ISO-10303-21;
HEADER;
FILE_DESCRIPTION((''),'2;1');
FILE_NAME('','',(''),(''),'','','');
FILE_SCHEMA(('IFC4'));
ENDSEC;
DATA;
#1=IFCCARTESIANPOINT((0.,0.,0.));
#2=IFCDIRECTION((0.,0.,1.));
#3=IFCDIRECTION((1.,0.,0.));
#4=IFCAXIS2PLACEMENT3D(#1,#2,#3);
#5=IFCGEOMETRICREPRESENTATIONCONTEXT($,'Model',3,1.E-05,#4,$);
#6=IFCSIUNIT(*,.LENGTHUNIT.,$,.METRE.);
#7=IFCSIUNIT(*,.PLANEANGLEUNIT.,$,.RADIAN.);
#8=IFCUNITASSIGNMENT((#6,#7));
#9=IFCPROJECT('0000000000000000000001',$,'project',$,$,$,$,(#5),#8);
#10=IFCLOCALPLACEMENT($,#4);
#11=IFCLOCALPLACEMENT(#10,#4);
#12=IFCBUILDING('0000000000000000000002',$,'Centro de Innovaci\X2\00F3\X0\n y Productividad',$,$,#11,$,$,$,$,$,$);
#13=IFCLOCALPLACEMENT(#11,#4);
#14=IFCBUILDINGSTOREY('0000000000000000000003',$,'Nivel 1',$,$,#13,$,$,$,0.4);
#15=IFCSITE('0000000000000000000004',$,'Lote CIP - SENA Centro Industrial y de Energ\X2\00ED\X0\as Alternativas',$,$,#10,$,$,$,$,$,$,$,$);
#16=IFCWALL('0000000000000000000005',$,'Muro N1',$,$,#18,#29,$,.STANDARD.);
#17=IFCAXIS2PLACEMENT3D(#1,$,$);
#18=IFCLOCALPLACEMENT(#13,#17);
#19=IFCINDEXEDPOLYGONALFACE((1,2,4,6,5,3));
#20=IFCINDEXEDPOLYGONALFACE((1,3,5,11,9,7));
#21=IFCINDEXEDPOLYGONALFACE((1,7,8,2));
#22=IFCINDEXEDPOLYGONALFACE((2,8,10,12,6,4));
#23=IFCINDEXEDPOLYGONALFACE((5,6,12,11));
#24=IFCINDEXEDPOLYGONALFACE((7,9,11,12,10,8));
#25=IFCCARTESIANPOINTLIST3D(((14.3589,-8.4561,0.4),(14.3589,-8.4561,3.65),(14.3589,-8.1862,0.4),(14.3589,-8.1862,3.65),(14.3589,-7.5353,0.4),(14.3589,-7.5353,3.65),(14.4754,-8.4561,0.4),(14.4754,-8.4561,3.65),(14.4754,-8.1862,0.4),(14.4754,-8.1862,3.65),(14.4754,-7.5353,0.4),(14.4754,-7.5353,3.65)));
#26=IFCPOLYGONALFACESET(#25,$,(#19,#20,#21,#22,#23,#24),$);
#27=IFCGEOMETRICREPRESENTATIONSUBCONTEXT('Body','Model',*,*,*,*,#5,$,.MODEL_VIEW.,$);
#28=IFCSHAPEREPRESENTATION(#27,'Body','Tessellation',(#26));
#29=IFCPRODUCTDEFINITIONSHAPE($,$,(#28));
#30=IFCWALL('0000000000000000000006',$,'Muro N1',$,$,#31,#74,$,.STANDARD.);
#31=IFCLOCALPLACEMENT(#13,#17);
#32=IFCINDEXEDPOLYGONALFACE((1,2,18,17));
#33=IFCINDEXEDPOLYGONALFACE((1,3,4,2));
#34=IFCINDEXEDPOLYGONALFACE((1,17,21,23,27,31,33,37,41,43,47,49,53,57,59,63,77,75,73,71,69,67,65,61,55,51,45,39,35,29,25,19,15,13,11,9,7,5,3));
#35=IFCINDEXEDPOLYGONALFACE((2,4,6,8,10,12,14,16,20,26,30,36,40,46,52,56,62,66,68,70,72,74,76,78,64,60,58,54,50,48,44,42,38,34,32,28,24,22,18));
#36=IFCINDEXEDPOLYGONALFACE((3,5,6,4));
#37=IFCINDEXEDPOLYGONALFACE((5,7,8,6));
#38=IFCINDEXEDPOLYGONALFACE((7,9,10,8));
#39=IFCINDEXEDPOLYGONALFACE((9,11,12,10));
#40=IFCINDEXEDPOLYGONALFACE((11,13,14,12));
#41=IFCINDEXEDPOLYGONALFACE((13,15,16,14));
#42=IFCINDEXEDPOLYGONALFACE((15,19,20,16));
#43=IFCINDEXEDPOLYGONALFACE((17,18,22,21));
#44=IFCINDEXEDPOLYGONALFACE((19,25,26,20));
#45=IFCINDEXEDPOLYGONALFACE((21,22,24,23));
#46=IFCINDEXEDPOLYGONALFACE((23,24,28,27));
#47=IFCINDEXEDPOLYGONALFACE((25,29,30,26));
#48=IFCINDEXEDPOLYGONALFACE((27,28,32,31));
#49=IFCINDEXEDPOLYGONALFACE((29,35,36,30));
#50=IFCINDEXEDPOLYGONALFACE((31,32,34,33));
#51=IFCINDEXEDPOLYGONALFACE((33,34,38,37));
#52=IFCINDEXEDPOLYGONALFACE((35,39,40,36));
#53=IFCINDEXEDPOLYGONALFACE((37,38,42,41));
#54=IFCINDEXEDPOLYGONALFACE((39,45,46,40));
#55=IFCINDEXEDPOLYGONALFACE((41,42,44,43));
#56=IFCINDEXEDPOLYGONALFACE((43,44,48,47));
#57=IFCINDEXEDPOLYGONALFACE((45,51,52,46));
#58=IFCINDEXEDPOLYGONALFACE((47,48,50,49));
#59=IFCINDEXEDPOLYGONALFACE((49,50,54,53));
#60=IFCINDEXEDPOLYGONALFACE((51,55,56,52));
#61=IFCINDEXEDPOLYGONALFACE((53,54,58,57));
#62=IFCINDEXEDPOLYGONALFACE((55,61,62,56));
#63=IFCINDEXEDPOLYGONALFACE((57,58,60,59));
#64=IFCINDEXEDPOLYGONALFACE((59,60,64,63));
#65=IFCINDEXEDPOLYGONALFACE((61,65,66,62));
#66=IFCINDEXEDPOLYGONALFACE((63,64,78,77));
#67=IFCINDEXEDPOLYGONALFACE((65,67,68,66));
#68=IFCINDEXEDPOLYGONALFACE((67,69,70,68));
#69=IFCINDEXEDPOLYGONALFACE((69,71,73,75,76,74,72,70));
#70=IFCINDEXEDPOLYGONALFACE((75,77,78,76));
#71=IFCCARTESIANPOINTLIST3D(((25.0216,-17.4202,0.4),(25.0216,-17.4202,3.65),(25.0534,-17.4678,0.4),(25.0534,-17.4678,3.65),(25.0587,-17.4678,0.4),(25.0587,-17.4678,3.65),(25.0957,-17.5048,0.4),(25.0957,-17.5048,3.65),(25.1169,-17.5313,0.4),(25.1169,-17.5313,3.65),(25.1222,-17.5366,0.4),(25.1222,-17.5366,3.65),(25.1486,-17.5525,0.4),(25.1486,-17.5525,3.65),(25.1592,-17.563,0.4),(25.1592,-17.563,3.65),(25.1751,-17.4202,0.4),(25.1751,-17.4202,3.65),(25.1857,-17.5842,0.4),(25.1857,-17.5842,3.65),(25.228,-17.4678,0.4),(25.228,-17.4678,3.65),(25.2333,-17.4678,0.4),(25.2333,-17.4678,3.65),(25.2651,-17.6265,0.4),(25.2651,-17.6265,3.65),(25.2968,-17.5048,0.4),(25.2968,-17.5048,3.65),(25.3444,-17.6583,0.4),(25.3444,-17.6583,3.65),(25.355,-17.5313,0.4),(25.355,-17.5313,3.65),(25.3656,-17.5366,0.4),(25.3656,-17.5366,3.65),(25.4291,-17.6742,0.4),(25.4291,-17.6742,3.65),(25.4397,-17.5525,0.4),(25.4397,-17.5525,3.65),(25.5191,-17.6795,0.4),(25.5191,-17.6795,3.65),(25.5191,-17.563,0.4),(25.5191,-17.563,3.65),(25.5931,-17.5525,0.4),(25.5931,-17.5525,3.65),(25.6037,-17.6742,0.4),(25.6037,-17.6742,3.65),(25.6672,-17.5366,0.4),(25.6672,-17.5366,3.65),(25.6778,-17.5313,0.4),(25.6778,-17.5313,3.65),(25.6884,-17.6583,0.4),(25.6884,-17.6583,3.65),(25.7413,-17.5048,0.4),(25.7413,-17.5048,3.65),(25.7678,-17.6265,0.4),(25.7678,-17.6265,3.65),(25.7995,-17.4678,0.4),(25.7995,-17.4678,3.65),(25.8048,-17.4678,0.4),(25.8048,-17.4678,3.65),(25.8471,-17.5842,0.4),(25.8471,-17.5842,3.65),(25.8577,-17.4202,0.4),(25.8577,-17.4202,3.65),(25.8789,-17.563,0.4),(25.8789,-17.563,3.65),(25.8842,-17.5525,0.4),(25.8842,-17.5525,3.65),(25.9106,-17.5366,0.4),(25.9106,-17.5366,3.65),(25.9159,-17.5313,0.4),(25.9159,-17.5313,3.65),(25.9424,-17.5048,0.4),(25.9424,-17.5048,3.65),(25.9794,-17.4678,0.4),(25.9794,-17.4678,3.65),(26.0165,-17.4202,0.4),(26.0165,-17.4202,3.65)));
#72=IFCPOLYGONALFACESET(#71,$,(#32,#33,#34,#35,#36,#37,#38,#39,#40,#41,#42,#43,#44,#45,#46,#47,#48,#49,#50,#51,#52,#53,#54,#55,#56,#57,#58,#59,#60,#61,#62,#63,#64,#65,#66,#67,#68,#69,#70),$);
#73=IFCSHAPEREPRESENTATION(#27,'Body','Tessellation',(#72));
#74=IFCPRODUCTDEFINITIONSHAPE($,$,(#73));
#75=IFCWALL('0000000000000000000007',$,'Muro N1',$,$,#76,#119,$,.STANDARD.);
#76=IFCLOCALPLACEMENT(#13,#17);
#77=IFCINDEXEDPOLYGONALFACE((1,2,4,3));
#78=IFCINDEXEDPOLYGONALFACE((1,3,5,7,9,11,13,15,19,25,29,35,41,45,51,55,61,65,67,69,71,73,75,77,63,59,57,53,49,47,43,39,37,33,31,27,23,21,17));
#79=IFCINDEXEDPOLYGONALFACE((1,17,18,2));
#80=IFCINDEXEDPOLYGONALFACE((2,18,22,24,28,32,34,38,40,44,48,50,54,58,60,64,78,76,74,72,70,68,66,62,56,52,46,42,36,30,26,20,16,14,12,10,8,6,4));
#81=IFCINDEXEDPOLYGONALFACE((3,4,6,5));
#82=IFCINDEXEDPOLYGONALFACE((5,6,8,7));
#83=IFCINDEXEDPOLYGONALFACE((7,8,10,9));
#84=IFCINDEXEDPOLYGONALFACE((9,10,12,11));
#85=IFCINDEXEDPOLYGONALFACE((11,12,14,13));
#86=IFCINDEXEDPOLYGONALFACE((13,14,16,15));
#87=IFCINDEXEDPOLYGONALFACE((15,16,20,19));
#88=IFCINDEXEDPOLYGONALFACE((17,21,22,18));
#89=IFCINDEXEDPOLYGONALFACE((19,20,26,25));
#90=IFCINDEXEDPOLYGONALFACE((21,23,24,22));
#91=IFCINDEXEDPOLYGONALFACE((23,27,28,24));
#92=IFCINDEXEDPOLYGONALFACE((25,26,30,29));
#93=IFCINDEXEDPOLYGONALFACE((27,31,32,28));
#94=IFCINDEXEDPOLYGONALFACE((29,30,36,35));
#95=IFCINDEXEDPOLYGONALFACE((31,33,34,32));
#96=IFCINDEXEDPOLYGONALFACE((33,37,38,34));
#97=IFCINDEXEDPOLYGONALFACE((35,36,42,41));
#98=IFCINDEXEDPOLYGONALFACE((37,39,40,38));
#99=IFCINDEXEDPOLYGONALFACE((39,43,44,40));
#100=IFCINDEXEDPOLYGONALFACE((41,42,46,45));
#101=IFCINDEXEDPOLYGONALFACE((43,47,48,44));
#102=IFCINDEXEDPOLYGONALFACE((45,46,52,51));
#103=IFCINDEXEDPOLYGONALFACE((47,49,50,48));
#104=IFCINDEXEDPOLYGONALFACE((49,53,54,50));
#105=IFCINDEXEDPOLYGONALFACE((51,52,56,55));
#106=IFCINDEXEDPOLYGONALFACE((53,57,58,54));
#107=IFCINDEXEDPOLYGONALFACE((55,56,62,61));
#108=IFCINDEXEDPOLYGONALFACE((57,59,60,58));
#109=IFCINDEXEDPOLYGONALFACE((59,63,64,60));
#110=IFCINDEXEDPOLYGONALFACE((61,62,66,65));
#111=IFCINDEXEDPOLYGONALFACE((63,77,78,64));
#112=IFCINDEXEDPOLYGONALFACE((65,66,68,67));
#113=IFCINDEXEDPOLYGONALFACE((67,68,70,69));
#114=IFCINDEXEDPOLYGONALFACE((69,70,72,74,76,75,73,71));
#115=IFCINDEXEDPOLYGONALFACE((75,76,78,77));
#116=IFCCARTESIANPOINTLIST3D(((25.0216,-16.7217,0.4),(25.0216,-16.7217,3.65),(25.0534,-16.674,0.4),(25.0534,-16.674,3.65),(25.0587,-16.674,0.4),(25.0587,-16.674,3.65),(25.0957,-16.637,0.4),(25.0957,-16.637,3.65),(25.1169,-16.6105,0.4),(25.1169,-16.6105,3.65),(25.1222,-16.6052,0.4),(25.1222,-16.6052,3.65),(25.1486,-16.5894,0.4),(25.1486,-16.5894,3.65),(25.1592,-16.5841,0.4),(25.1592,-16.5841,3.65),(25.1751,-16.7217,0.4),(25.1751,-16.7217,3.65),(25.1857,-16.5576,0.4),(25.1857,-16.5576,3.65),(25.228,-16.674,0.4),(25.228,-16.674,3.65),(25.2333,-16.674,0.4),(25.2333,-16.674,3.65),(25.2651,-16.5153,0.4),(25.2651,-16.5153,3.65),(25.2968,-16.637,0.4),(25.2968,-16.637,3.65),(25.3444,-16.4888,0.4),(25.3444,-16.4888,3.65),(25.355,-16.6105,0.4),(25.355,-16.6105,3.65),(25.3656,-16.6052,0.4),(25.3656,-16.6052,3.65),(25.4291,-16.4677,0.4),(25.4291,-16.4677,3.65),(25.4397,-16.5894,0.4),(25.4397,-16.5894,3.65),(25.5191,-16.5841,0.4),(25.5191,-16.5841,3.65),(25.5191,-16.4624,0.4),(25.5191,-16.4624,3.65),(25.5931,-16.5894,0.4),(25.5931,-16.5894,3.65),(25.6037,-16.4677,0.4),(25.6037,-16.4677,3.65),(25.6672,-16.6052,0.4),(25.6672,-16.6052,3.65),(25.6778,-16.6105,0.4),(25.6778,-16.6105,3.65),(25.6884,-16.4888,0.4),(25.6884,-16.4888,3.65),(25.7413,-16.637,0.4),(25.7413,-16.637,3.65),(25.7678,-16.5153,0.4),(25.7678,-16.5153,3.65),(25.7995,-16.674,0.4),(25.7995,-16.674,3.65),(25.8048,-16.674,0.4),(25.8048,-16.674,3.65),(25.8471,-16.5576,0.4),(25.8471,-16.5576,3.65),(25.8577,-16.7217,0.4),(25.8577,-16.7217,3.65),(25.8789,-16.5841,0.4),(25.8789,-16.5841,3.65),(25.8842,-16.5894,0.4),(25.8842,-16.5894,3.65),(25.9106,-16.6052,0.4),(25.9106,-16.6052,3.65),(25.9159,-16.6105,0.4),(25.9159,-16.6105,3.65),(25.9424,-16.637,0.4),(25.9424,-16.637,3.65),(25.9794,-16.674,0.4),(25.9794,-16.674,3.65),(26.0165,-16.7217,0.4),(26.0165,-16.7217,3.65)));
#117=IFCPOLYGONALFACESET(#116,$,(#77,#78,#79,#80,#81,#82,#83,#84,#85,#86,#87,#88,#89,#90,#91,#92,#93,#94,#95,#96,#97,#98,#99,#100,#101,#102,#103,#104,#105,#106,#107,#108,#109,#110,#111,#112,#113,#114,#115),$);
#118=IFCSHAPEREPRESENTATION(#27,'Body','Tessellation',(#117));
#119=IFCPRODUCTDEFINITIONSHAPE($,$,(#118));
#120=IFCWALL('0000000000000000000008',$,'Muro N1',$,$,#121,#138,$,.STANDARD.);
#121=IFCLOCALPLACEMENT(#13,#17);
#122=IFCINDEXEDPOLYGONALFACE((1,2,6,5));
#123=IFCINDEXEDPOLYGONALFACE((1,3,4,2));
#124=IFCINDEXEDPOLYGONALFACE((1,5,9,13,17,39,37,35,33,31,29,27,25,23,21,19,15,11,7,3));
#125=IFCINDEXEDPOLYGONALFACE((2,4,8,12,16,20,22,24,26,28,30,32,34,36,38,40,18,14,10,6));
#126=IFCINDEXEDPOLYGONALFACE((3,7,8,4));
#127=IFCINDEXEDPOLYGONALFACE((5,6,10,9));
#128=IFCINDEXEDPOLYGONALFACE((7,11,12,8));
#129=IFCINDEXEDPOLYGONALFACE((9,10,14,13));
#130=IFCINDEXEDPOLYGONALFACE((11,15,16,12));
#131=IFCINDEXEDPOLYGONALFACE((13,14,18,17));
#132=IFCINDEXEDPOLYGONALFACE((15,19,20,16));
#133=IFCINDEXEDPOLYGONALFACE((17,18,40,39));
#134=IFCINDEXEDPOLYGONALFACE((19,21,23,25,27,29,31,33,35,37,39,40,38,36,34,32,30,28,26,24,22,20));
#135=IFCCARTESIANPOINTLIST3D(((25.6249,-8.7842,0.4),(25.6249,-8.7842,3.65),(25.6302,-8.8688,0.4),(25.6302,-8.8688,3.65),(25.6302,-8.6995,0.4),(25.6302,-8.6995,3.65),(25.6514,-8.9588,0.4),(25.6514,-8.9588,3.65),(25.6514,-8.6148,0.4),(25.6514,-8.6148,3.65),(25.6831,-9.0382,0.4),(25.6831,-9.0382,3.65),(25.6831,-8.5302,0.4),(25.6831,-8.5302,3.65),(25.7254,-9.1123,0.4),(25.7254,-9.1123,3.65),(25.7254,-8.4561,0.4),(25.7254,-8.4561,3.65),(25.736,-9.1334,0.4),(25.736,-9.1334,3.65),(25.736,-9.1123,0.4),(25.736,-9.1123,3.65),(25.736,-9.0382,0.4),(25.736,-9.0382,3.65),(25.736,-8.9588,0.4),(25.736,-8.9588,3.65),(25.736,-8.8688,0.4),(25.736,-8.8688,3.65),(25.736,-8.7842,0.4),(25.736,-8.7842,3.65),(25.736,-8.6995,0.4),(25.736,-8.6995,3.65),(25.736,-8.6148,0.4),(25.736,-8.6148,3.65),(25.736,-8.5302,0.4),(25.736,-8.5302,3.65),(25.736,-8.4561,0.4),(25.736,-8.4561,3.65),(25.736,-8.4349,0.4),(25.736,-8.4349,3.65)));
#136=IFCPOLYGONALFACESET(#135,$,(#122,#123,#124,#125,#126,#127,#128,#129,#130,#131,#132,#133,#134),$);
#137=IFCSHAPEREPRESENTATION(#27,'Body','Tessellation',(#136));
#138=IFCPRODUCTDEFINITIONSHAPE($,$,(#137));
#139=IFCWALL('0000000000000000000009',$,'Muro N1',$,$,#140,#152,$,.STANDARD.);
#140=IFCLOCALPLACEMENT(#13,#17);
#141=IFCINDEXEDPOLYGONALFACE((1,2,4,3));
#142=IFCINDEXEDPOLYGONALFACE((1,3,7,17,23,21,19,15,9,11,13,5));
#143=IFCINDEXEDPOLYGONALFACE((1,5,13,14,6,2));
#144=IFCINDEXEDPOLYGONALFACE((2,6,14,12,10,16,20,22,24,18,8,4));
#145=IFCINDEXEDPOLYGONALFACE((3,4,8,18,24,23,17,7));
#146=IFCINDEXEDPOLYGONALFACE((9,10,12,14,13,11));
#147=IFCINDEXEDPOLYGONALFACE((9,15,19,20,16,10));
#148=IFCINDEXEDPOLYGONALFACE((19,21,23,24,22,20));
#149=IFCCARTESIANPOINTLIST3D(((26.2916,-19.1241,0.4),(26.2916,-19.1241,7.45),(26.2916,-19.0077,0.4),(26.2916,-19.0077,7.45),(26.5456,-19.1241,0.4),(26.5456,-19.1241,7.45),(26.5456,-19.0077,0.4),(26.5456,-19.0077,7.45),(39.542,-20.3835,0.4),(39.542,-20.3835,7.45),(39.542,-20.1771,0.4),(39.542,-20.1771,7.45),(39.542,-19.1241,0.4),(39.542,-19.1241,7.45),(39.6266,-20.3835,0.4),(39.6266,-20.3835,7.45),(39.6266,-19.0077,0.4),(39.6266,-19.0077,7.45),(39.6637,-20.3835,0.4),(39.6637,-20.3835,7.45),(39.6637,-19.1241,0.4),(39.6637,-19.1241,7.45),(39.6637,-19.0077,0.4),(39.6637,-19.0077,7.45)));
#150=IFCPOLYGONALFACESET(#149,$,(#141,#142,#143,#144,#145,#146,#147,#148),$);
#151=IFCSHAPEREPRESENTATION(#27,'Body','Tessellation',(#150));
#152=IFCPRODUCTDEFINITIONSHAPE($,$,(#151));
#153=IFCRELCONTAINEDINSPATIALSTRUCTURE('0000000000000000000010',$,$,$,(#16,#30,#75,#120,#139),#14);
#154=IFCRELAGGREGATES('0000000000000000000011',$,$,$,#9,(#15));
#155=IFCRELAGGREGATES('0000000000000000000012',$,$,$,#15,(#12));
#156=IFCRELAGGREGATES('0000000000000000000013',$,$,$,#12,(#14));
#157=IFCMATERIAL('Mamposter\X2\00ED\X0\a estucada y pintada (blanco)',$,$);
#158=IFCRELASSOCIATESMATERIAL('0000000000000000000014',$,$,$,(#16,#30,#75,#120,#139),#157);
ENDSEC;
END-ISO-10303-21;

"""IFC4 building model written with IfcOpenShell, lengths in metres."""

from ifc_helpers import new_model, si_unit, frame, origin_with_axes, place, context, subcontext, project, spatial, polyline, outline, extrude, material, element, save


model = new_model("IFC4")

# Units and contexts
model_context = context("Model", 3, precision=1e-05, world=origin_with_axes())
body_context = subcontext(model_context, "Body", "Model", "MODEL_VIEW")
ifc_project = project(units=[si_unit("LENGTHUNIT", "METRE"), si_unit("PLANEANGLEUNIT", "RADIAN")], contexts=[model_context])

# Site, building, storey
site_placement = place(None, origin_with_axes())
site = spatial("IfcSite", under=ifc_project, at=site_placement, Name="Lote CIP - SENA Centro Industrial y de Energías Alternativas")
building_placement = place(site_placement, origin_with_axes())
building = spatial("IfcBuilding", under=site, at=building_placement, Name="Centro de Innovación y Productividad")
storey_placement = place(building_placement, origin_with_axes())
storey = spatial("IfcBuildingStorey", under=building, at=storey_placement, Name="Nivel 1", Elevation=0.4)

# Walls
ifc_material = material(Name="Mampostería estucada y pintada (blanco)")
wall_1_placement = place(storey_placement, origin_with_axes())
element("IfcWall", 1, at=wall_1_placement, inside=storey, material=ifc_material, Name="Muro N1", PredefinedType="STANDARD", context=body_context, shape_type="SweptSolid", body=[
    extrude(outline(polyline([(14.4754, -8.4561), (14.3589, -8.4561), (14.3589, -8.1862), (14.3589, -7.5353), (14.4754, -7.5353), (14.4754, -8.1862), (14.4754, -8.4561)])), frame((0.0, 0.0, 0.4)), (0.0, 0.0, 1.0), 3.25),
])
wall_2_placement = place(storey_placement, origin_with_axes())
element("IfcWall", 2, at=wall_2_placement, inside=storey, material=ifc_material, Name="Muro N1", PredefinedType="STANDARD", context=body_context, shape_type="SweptSolid", body=[
    extrude(outline(polyline([(25.1169, -17.5313), (25.0957, -17.5048), (25.0587, -17.4678), (25.0534, -17.4678), (25.0216, -17.4202), (25.1751, -17.4202), (25.228, -17.4678), (25.2333, -17.4678), (25.2968, -17.5048), (25.355, -17.5313), (25.3656, -17.5366), (25.4397, -17.5525), (25.5191, -17.563), (25.5931, -17.5525), (25.6672, -17.5366), (25.6778, -17.5313), (25.7413, -17.5048), (25.7995, -17.4678), (25.8048, -17.4678), (25.8577, -17.4202), (26.0165, -17.4202), (25.9794, -17.4678), (25.9424, -17.5048), (25.9159, -17.5313), (25.9106, -17.5366), (25.8842, -17.5525), (25.8789, -17.563), (25.8471, -17.5842), (25.7678, -17.6265), (25.6884, -17.6583), (25.6037, -17.6742), (25.5191, -17.6795), (25.4291, -17.6742), (25.3444, -17.6583), (25.2651, -17.6265), (25.1857, -17.5842), (25.1592, -17.563), (25.1486, -17.5525), (25.1222, -17.5366), (25.1169, -17.5313)])), frame((0.0, 0.0, 0.4)), (0.0, 0.0, 1.0), 3.25),
])
wall_3_placement = place(storey_placement, origin_with_axes())
element("IfcWall", 3, at=wall_3_placement, inside=storey, material=ifc_material, Name="Muro N1", PredefinedType="STANDARD", context=body_context, shape_type="SweptSolid", body=[
    extrude(outline(polyline([(25.1857, -16.5576), (25.2651, -16.5153), (25.3444, -16.4888), (25.4291, -16.4677), (25.5191, -16.4624), (25.6037, -16.4677), (25.6884, -16.4888), (25.7678, -16.5153), (25.8471, -16.5576), (25.8789, -16.5841), (25.8842, -16.5894), (25.9106, -16.6052), (25.9159, -16.6105), (25.9424, -16.637), (25.9794, -16.674), (26.0165, -16.7217), (25.8577, -16.7217), (25.8048, -16.674), (25.7995, -16.674), (25.7413, -16.637), (25.6778, -16.6105), (25.6672, -16.6052), (25.5931, -16.5894), (25.5191, -16.5841), (25.4397, -16.5894), (25.3656, -16.6052), (25.355, -16.6105), (25.2968, -16.637), (25.2333, -16.674), (25.228, -16.674), (25.1751, -16.7217), (25.0216, -16.7217), (25.0534, -16.674), (25.0587, -16.674), (25.0957, -16.637), (25.1169, -16.6105), (25.1222, -16.6052), (25.1486, -16.5894), (25.1592, -16.5841), (25.1857, -16.5576)])), frame((0.0, 0.0, 0.4)), (0.0, 0.0, 1.0), 3.25),
])
wall_4_placement = place(storey_placement, origin_with_axes())
element("IfcWall", 4, at=wall_4_placement, inside=storey, material=ifc_material, Name="Muro N1", PredefinedType="STANDARD", context=body_context, shape_type="SweptSolid", body=[
    extrude(outline(polyline([(25.6831, -8.5302), (25.7254, -8.4561), (25.736, -8.4349), (25.736, -8.4561), (25.736, -8.5302), (25.736, -8.6148), (25.736, -8.6995), (25.736, -8.7842), (25.736, -8.8688), (25.736, -8.9588), (25.736, -9.0382), (25.736, -9.1123), (25.736, -9.1334), (25.7254, -9.1123), (25.6831, -9.0382), (25.6514, -8.9588), (25.6302, -8.8688), (25.6249, -8.7842), (25.6302, -8.6995), (25.6514, -8.6148), (25.6831, -8.5302)])), frame((0.0, 0.0, 0.4)), (0.0, 0.0, 1.0), 3.25),
])
wall_5_placement = place(storey_placement, origin_with_axes())
element("IfcWall", 5, at=wall_5_placement, inside=storey, material=ifc_material, Name="Muro N1", PredefinedType="STANDARD", context=body_context, shape_type="SweptSolid", body=[
    extrude(outline(polyline([(26.2916, -19.0077), (26.5456, -19.0077), (39.6266, -19.0077), (39.6637, -19.0077), (39.6637, -19.1241), (39.6637, -20.3835), (39.6266, -20.3835), (39.542, -20.3835), (39.542, -20.1771), (39.542, -19.1241), (26.5456, -19.1241), (26.2916, -19.1241), (26.2916, -19.0077)])), frame((0.0, 0.0, 0.4)), (0.0, 0.0, 1.0), 7.05),
])

save(model, "model.ifc")
